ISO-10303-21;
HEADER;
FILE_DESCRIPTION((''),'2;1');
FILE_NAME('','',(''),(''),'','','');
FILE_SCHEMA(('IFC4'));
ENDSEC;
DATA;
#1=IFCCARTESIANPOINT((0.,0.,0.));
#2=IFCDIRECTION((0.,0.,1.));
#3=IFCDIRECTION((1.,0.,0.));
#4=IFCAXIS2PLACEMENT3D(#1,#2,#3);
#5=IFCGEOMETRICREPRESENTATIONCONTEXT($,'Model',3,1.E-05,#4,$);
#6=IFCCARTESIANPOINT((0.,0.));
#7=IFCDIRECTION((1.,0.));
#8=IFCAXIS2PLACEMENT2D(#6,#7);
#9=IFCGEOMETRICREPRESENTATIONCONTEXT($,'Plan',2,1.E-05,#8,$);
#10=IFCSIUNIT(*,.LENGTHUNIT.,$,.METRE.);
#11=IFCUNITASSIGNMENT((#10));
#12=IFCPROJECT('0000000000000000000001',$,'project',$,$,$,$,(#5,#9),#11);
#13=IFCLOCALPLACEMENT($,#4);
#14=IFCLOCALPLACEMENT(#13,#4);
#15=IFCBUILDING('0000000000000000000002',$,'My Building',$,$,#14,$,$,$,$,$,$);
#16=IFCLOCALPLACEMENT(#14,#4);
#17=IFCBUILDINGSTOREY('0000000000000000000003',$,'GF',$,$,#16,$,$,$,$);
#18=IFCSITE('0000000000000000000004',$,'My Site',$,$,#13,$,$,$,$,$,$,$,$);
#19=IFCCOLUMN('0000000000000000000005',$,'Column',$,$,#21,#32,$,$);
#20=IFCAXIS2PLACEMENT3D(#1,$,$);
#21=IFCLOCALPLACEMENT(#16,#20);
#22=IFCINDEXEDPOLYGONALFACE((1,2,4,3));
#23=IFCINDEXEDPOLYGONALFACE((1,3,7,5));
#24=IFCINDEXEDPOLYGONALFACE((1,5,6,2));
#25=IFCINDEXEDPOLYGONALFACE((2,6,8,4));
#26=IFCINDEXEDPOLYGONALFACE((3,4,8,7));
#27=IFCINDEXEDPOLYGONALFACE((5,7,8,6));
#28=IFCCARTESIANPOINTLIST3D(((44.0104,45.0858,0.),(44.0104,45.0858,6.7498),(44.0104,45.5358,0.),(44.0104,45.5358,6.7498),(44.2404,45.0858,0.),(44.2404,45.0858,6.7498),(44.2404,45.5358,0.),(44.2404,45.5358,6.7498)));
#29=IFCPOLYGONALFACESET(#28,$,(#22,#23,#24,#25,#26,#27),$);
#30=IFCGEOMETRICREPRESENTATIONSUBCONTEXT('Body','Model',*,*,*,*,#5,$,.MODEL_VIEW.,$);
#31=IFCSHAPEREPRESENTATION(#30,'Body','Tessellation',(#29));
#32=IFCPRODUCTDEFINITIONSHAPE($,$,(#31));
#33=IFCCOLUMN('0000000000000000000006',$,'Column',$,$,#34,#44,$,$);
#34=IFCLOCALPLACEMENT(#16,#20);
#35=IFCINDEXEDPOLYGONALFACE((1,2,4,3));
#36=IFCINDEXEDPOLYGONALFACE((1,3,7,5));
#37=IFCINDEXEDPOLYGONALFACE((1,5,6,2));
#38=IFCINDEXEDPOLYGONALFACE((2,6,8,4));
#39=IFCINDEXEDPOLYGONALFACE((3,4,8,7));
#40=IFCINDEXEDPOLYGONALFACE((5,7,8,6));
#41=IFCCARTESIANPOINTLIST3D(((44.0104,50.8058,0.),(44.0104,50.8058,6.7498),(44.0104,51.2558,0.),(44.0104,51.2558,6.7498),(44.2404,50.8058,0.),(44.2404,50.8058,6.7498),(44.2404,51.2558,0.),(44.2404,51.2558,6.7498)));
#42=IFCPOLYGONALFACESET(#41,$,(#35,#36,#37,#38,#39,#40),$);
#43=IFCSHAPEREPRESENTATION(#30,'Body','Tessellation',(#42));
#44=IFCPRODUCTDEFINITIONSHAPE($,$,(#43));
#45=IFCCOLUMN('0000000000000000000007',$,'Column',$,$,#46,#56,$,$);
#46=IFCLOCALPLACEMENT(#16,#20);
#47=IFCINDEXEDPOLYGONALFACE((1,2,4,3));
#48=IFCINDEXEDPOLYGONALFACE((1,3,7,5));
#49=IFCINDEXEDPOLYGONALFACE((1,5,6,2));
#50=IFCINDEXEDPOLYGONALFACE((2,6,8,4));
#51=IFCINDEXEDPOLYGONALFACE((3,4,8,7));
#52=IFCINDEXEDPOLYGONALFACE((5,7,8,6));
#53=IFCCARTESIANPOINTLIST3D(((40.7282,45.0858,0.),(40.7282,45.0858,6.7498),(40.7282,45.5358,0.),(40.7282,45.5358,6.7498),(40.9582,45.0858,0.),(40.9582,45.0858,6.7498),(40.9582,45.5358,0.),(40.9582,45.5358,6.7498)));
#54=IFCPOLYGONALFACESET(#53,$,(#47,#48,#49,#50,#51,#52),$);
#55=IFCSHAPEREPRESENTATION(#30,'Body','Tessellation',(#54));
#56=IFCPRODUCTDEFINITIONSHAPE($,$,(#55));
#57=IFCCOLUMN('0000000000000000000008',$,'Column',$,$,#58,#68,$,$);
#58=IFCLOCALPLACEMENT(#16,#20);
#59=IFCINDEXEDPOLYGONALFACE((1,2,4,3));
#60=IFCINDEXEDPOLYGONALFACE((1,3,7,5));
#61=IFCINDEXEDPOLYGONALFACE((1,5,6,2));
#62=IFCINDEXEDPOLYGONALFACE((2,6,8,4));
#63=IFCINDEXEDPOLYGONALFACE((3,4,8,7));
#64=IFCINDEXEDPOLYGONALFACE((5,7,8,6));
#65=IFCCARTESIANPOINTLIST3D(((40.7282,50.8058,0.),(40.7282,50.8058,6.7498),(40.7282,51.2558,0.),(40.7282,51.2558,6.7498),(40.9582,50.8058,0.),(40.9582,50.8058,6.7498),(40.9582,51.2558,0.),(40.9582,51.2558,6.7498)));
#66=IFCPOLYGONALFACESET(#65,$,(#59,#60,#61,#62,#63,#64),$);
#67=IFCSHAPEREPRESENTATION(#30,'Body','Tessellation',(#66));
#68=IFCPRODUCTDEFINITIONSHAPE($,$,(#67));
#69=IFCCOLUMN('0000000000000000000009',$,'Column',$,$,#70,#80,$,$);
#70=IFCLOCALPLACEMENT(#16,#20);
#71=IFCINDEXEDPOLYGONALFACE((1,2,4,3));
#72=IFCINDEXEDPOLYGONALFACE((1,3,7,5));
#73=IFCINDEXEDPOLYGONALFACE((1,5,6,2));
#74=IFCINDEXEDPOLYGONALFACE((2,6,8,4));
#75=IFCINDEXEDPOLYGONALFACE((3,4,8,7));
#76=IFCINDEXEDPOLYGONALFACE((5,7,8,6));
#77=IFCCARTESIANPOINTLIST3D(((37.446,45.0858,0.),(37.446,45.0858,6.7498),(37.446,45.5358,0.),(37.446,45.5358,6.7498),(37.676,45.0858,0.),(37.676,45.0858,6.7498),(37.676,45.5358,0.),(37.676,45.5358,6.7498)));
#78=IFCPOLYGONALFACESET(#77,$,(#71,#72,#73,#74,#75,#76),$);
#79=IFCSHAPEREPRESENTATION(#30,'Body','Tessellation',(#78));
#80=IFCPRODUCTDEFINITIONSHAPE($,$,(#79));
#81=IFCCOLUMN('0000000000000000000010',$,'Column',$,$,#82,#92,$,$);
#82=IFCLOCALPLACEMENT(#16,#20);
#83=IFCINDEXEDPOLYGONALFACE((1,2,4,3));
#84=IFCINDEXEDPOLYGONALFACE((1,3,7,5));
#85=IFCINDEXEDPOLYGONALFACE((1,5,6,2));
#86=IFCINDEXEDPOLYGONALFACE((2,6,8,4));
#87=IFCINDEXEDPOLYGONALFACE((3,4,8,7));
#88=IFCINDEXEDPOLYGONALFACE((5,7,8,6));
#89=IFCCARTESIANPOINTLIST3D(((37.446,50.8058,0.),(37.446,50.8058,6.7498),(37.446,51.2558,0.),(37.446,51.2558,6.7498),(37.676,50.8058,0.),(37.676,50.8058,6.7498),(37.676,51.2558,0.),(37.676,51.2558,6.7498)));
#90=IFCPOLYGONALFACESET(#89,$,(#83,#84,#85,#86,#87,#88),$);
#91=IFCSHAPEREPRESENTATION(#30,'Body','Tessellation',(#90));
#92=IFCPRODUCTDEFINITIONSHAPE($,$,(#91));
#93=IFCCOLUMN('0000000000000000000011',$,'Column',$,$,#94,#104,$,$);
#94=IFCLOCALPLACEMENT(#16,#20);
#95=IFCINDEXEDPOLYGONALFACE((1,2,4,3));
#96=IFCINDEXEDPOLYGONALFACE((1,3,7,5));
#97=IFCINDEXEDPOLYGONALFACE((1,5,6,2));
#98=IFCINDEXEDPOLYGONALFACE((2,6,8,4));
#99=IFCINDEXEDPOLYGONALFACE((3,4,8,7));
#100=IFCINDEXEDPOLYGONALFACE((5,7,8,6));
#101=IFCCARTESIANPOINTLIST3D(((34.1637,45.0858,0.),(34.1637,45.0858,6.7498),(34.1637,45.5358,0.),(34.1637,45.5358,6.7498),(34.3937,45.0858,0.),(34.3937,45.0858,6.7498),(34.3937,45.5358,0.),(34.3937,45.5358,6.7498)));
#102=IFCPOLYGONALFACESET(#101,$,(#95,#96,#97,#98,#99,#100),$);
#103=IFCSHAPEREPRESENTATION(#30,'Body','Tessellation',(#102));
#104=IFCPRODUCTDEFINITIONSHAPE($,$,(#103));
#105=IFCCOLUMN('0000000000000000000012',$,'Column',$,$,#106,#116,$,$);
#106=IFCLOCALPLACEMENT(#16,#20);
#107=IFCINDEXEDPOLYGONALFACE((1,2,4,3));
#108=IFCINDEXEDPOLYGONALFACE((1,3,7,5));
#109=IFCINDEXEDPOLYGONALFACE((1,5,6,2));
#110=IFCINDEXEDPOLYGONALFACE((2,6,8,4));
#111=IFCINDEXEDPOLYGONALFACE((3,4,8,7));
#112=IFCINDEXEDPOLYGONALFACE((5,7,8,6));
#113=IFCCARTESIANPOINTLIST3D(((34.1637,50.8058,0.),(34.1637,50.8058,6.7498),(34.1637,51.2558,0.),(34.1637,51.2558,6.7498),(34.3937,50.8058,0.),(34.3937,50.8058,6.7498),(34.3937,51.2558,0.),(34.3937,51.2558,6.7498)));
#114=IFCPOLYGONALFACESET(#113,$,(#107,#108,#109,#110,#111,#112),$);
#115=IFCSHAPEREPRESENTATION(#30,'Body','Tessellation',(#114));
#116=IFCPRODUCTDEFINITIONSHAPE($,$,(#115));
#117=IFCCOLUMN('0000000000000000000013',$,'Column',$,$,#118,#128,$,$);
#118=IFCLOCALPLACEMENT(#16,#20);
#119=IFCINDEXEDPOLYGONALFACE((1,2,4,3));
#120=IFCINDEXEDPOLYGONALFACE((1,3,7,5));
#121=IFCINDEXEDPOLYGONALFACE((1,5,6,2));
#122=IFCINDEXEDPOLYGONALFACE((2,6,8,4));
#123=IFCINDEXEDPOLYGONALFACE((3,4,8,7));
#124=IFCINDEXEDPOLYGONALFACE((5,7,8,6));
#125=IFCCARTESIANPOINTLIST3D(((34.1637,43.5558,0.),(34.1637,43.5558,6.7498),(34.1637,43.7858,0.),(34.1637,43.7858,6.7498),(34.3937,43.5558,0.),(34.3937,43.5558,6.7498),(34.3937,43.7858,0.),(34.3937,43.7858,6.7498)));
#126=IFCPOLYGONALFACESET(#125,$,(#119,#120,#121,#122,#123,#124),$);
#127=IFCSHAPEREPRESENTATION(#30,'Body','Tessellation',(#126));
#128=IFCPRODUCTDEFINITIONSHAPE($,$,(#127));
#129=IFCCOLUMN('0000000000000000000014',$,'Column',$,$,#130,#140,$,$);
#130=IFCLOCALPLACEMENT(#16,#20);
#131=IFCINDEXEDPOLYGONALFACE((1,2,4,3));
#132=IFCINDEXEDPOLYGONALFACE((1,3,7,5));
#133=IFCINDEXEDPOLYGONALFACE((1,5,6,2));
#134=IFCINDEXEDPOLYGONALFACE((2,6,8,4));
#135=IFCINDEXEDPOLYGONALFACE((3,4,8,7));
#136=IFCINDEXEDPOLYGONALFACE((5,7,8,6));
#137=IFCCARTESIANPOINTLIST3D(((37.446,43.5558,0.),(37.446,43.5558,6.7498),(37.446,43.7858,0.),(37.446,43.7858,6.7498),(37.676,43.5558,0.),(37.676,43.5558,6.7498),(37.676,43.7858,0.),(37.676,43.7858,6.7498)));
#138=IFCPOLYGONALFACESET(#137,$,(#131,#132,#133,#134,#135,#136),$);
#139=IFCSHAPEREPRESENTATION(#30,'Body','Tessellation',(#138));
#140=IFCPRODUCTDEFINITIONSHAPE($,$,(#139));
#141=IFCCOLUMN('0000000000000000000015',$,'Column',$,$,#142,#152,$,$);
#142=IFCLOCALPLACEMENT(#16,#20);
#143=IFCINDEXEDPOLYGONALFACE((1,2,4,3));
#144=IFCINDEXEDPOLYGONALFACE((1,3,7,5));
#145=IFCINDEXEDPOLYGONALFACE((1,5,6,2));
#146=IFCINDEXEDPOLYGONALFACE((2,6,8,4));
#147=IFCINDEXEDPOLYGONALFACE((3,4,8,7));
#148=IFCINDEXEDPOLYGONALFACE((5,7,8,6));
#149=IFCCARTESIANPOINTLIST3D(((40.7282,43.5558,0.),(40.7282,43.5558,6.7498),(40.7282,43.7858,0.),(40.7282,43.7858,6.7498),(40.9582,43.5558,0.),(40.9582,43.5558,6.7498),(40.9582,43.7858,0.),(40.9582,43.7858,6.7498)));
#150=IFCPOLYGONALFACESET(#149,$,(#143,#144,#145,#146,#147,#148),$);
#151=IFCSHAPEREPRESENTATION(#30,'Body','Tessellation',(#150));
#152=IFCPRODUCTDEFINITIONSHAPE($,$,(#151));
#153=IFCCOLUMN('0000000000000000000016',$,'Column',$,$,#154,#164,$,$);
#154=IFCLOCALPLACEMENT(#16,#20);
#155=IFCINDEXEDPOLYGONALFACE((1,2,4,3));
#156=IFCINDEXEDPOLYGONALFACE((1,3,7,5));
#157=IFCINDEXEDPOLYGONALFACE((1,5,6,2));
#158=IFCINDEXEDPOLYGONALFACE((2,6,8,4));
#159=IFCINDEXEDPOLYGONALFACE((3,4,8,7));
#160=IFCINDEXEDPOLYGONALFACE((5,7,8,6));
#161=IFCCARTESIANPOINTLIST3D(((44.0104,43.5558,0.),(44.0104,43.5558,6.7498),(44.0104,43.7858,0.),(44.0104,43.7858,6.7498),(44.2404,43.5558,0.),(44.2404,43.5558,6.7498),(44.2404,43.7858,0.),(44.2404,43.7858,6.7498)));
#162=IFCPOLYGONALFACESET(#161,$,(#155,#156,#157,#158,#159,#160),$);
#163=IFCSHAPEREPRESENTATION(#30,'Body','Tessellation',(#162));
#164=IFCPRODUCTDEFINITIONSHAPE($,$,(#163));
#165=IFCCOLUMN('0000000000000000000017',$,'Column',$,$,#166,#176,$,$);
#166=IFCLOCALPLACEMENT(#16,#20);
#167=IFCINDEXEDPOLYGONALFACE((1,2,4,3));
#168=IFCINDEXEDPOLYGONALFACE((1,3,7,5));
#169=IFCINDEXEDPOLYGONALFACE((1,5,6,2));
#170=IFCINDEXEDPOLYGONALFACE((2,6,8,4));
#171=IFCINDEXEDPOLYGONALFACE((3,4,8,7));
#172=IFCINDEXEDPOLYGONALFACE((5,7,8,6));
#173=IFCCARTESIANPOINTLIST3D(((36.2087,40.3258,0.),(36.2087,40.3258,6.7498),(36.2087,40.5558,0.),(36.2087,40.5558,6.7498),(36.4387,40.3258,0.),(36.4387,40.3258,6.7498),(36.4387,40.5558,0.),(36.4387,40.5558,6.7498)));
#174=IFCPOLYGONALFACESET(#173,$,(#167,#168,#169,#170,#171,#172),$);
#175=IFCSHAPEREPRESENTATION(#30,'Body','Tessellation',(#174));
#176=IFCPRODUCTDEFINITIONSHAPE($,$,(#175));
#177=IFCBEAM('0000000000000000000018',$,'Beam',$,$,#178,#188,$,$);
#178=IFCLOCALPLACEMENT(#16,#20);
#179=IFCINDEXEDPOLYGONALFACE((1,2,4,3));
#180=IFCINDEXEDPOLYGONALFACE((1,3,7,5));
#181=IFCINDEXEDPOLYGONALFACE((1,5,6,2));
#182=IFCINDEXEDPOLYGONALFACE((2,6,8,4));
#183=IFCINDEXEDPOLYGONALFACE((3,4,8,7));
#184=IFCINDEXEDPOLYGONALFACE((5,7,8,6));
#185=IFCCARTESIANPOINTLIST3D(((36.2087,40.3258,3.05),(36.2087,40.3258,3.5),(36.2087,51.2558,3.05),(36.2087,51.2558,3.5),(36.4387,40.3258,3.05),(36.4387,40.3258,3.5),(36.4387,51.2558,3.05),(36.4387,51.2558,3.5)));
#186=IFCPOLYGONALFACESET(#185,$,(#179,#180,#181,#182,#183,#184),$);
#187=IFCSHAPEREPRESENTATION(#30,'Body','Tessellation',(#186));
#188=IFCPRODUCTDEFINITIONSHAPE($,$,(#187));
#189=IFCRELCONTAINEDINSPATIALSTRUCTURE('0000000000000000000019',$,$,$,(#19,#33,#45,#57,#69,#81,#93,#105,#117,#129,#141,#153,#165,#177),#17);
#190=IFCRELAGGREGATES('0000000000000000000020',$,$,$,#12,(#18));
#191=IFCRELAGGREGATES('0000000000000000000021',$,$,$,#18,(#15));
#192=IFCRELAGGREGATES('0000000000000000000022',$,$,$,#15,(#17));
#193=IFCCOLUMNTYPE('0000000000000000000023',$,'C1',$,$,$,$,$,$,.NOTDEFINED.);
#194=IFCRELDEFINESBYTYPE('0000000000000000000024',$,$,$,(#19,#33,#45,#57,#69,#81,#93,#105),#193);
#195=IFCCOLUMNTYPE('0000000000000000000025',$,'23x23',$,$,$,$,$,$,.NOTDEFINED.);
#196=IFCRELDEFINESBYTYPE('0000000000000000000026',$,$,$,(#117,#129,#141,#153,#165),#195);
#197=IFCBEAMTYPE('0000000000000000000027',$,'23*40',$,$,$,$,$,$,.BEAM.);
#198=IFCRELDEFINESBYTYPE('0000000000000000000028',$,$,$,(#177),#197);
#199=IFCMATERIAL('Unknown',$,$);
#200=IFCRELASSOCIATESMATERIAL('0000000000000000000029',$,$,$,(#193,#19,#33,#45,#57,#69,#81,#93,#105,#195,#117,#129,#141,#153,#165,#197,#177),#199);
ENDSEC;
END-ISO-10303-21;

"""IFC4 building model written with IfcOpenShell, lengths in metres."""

from ifc_helpers import new_model, si_unit, frame, origin_with_axes, origin_2d_with_axis, place, context, subcontext, project, spatial, rectangle, extrude, material, material_profile, profile_set, profile_usage, type_object, element, save


model = new_model("IFC4")

# Units and contexts
model_context = context("Model", 3, precision=1e-05, world=origin_with_axes())
plan_context = context("Plan", 2, precision=1e-05, world=origin_2d_with_axis())
body_context = subcontext(model_context, "Body", "Model", "MODEL_VIEW")
ifc_project = project(units=[si_unit("LENGTHUNIT", "METRE")], contexts=[model_context, plan_context])

# Site, building, storey
site_placement = place(None, origin_with_axes())
site = spatial("IfcSite", under=ifc_project, at=site_placement, Name="My Site")
building_placement = place(site_placement, origin_with_axes())
building = spatial("IfcBuilding", under=site, at=building_placement, Name="My Building")
storey_placement = place(building_placement, origin_with_axes())
storey = spatial("IfcBuildingStorey", under=building, at=storey_placement, Name="GF")

# Columns
ifc_material = material(Name="Unknown")
ifc_material_profile_1 = material_profile(ifc_material, rectangle(XDim=0.45, YDim=0.23))
ifc_profile_set_1 = profile_set([ifc_material_profile_1])
ifc_profile_usage_1 = profile_usage(ifc_profile_set_1, cardinal=5)
column_type_1 = type_object("IfcColumnType", Name="C1", PredefinedType="NOTDEFINED", material=ifc_profile_set_1)
column_1_placement = place(storey_placement, frame((44.1254, 45.3108, 0.0), z_axis=(0.0, 0.0, 1.0), x_axis=(0.0, 1.0, 0.0)))
element("IfcColumn", 1, at=column_1_placement, inside=storey, type_object=column_type_1, material=ifc_profile_usage_1, Name="Column", context=body_context, shape_type="SweptSolid", body=[
    extrude(rectangle(XDim=0.45, YDim=0.23), origin_with_axes(), (0.0, 0.0, 1.0), 6.7498),
])
ifc_profile_usage_2 = profile_usage(ifc_profile_set_1, cardinal=5)
column_2_placement = place(storey_placement, frame((44.1254, 51.0308, 0.0), z_axis=(0.0, 0.0, 1.0), x_axis=(0.0, 1.0, 0.0)))
element("IfcColumn", 2, at=column_2_placement, inside=storey, type_object=column_type_1, material=ifc_profile_usage_2, Name="Column", context=body_context, shape_type="SweptSolid", body=[
    extrude(rectangle(XDim=0.45, YDim=0.23), origin_with_axes(), (0.0, 0.0, 1.0), 6.7498),
])
ifc_profile_usage_3 = profile_usage(ifc_profile_set_1, cardinal=5)
column_3_placement = place(storey_placement, frame((40.8432, 45.3108, 0.0), z_axis=(0.0, 0.0, 1.0), x_axis=(0.0, 1.0, 0.0)))
element("IfcColumn", 3, at=column_3_placement, inside=storey, type_object=column_type_1, material=ifc_profile_usage_3, Name="Column", context=body_context, shape_type="SweptSolid", body=[
    extrude(rectangle(XDim=0.45, YDim=0.23), origin_with_axes(), (0.0, 0.0, 1.0), 6.7498),
])
ifc_profile_usage_4 = profile_usage(ifc_profile_set_1, cardinal=5)
column_4_placement = place(storey_placement, frame((40.8432, 51.0308, 0.0), z_axis=(0.0, 0.0, 1.0), x_axis=(0.0, 1.0, 0.0)))
element("IfcColumn", 4, at=column_4_placement, inside=storey, type_object=column_type_1, material=ifc_profile_usage_4, Name="Column", context=body_context, shape_type="SweptSolid", body=[
    extrude(rectangle(XDim=0.45, YDim=0.23), origin_with_axes(), (0.0, 0.0, 1.0), 6.7498),
])
ifc_profile_usage_5 = profile_usage(ifc_profile_set_1, cardinal=5)
column_5_placement = place(storey_placement, frame((37.561, 45.3108, 0.0), z_axis=(0.0, 0.0, 1.0), x_axis=(0.0, 1.0, 0.0)))
element("IfcColumn", 5, at=column_5_placement, inside=storey, type_object=column_type_1, material=ifc_profile_usage_5, Name="Column", context=body_context, shape_type="SweptSolid", body=[
    extrude(rectangle(XDim=0.45, YDim=0.23), origin_with_axes(), (0.0, 0.0, 1.0), 6.7498),
])
ifc_profile_usage_6 = profile_usage(ifc_profile_set_1, cardinal=5)
column_6_placement = place(storey_placement, frame((37.561, 51.0308, 0.0), z_axis=(0.0, 0.0, 1.0), x_axis=(0.0, 1.0, 0.0)))
element("IfcColumn", 6, at=column_6_placement, inside=storey, type_object=column_type_1, material=ifc_profile_usage_6, Name="Column", context=body_context, shape_type="SweptSolid", body=[
    extrude(rectangle(XDim=0.45, YDim=0.23), origin_with_axes(), (0.0, 0.0, 1.0), 6.7498),
])
ifc_profile_usage_7 = profile_usage(ifc_profile_set_1, cardinal=5)
column_7_placement = place(storey_placement, frame((34.2787, 45.3108, 0.0), z_axis=(0.0, 0.0, 1.0), x_axis=(0.0, 1.0, 0.0)))
element("IfcColumn", 7, at=column_7_placement, inside=storey, type_object=column_type_1, material=ifc_profile_usage_7, Name="Column", context=body_context, shape_type="SweptSolid", body=[
    extrude(rectangle(XDim=0.45, YDim=0.23), origin_with_axes(), (0.0, 0.0, 1.0), 6.7498),
])
ifc_profile_usage_8 = profile_usage(ifc_profile_set_1, cardinal=5)
column_8_placement = place(storey_placement, frame((34.2787, 51.0308, 0.0), z_axis=(0.0, 0.0, 1.0), x_axis=(0.0, 1.0, 0.0)))
element("IfcColumn", 8, at=column_8_placement, inside=storey, type_object=column_type_1, material=ifc_profile_usage_8, Name="Column", context=body_context, shape_type="SweptSolid", body=[
    extrude(rectangle(XDim=0.45, YDim=0.23), origin_with_axes(), (0.0, 0.0, 1.0), 6.7498),
])
ifc_material_profile_2 = material_profile(ifc_material, rectangle(XDim=0.23, YDim=0.23))
ifc_profile_set_2 = profile_set([ifc_material_profile_2])
ifc_profile_usage_9 = profile_usage(ifc_profile_set_2, cardinal=5)
column_type_2 = type_object("IfcColumnType", Name="23x23", PredefinedType="NOTDEFINED", material=ifc_profile_set_2)
column_9_placement = place(storey_placement, frame((34.2787, 43.6708, 0.0), z_axis=(0.0, 0.0, 1.0), x_axis=(1.0, 0.0, 0.0)))
element("IfcColumn", 9, at=column_9_placement, inside=storey, type_object=column_type_2, material=ifc_profile_usage_9, Name="Column", context=body_context, shape_type="SweptSolid", body=[
    extrude(rectangle(XDim=0.23, YDim=0.23), origin_with_axes(), (0.0, 0.0, 1.0), 6.7498),
])
ifc_profile_usage_10 = profile_usage(ifc_profile_set_2, cardinal=5)
column_10_placement = place(storey_placement, frame((37.561, 43.6708, 0.0), z_axis=(0.0, 0.0, 1.0), x_axis=(1.0, 0.0, 0.0)))
element("IfcColumn", 10, at=column_10_placement, inside=storey, type_object=column_type_2, material=ifc_profile_usage_10, Name="Column", context=body_context, shape_type="SweptSolid", body=[
    extrude(rectangle(XDim=0.23, YDim=0.23), origin_with_axes(), (0.0, 0.0, 1.0), 6.7498),
])
ifc_profile_usage_11 = profile_usage(ifc_profile_set_2, cardinal=5)
column_11_placement = place(storey_placement, frame((40.8432, 43.6708, 0.0), z_axis=(0.0, 0.0, 1.0), x_axis=(1.0, 0.0, 0.0)))
element("IfcColumn", 11, at=column_11_placement, inside=storey, type_object=column_type_2, material=ifc_profile_usage_11, Name="Column", context=body_context, shape_type="SweptSolid", body=[
    extrude(rectangle(XDim=0.23, YDim=0.23), origin_with_axes(), (0.0, 0.0, 1.0), 6.7498),
])
ifc_profile_usage_12 = profile_usage(ifc_profile_set_2, cardinal=5)
column_12_placement = place(storey_placement, frame((44.1254, 43.6708, 0.0), z_axis=(0.0, 0.0, 1.0), x_axis=(1.0, 0.0, 0.0)))
element("IfcColumn", 12, at=column_12_placement, inside=storey, type_object=column_type_2, material=ifc_profile_usage_12, Name="Column", context=body_context, shape_type="SweptSolid", body=[
    extrude(rectangle(XDim=0.23, YDim=0.23), origin_with_axes(), (0.0, 0.0, 1.0), 6.7498),
])
ifc_profile_usage_13 = profile_usage(ifc_profile_set_2, cardinal=5)
column_13_placement = place(storey_placement, frame((36.3237, 40.4408, 0.0), z_axis=(0.0, 0.0, 1.0), x_axis=(1.0, 0.0, 0.0)))
element("IfcColumn", 13, at=column_13_placement, inside=storey, type_object=column_type_2, material=ifc_profile_usage_13, Name="Column", context=body_context, shape_type="SweptSolid", body=[
    extrude(rectangle(XDim=0.23, YDim=0.23), origin_with_axes(), (0.0, 0.0, 1.0), 6.7498),
])

# Beam
ifc_material_profile_3 = material_profile(ifc_material, rectangle(XDim=0.23, YDim=0.45))
ifc_profile_set_3 = profile_set([ifc_material_profile_3])
ifc_profile_usage_14 = profile_usage(ifc_profile_set_3, cardinal=5)
beam_type = type_object("IfcBeamType", Name="23*40", PredefinedType="BEAM", material=ifc_profile_set_3)
beam_1_placement = place(storey_placement, frame((36.3237, 40.3258, 3.275), z_axis=(0.0, 1.0, 0.0), x_axis=(-1.0, 0.0, 0.0)))
element("IfcBeam", 14, at=beam_1_placement, inside=storey, type_object=beam_type, material=ifc_profile_usage_14, Name="Beam", context=body_context, shape_type="SweptSolid", body=[
    extrude(rectangle(XDim=0.23, YDim=0.45), origin_with_axes(), (0.0, 0.0, 1.0), 10.93),
])

save(model, "model.ifc")
